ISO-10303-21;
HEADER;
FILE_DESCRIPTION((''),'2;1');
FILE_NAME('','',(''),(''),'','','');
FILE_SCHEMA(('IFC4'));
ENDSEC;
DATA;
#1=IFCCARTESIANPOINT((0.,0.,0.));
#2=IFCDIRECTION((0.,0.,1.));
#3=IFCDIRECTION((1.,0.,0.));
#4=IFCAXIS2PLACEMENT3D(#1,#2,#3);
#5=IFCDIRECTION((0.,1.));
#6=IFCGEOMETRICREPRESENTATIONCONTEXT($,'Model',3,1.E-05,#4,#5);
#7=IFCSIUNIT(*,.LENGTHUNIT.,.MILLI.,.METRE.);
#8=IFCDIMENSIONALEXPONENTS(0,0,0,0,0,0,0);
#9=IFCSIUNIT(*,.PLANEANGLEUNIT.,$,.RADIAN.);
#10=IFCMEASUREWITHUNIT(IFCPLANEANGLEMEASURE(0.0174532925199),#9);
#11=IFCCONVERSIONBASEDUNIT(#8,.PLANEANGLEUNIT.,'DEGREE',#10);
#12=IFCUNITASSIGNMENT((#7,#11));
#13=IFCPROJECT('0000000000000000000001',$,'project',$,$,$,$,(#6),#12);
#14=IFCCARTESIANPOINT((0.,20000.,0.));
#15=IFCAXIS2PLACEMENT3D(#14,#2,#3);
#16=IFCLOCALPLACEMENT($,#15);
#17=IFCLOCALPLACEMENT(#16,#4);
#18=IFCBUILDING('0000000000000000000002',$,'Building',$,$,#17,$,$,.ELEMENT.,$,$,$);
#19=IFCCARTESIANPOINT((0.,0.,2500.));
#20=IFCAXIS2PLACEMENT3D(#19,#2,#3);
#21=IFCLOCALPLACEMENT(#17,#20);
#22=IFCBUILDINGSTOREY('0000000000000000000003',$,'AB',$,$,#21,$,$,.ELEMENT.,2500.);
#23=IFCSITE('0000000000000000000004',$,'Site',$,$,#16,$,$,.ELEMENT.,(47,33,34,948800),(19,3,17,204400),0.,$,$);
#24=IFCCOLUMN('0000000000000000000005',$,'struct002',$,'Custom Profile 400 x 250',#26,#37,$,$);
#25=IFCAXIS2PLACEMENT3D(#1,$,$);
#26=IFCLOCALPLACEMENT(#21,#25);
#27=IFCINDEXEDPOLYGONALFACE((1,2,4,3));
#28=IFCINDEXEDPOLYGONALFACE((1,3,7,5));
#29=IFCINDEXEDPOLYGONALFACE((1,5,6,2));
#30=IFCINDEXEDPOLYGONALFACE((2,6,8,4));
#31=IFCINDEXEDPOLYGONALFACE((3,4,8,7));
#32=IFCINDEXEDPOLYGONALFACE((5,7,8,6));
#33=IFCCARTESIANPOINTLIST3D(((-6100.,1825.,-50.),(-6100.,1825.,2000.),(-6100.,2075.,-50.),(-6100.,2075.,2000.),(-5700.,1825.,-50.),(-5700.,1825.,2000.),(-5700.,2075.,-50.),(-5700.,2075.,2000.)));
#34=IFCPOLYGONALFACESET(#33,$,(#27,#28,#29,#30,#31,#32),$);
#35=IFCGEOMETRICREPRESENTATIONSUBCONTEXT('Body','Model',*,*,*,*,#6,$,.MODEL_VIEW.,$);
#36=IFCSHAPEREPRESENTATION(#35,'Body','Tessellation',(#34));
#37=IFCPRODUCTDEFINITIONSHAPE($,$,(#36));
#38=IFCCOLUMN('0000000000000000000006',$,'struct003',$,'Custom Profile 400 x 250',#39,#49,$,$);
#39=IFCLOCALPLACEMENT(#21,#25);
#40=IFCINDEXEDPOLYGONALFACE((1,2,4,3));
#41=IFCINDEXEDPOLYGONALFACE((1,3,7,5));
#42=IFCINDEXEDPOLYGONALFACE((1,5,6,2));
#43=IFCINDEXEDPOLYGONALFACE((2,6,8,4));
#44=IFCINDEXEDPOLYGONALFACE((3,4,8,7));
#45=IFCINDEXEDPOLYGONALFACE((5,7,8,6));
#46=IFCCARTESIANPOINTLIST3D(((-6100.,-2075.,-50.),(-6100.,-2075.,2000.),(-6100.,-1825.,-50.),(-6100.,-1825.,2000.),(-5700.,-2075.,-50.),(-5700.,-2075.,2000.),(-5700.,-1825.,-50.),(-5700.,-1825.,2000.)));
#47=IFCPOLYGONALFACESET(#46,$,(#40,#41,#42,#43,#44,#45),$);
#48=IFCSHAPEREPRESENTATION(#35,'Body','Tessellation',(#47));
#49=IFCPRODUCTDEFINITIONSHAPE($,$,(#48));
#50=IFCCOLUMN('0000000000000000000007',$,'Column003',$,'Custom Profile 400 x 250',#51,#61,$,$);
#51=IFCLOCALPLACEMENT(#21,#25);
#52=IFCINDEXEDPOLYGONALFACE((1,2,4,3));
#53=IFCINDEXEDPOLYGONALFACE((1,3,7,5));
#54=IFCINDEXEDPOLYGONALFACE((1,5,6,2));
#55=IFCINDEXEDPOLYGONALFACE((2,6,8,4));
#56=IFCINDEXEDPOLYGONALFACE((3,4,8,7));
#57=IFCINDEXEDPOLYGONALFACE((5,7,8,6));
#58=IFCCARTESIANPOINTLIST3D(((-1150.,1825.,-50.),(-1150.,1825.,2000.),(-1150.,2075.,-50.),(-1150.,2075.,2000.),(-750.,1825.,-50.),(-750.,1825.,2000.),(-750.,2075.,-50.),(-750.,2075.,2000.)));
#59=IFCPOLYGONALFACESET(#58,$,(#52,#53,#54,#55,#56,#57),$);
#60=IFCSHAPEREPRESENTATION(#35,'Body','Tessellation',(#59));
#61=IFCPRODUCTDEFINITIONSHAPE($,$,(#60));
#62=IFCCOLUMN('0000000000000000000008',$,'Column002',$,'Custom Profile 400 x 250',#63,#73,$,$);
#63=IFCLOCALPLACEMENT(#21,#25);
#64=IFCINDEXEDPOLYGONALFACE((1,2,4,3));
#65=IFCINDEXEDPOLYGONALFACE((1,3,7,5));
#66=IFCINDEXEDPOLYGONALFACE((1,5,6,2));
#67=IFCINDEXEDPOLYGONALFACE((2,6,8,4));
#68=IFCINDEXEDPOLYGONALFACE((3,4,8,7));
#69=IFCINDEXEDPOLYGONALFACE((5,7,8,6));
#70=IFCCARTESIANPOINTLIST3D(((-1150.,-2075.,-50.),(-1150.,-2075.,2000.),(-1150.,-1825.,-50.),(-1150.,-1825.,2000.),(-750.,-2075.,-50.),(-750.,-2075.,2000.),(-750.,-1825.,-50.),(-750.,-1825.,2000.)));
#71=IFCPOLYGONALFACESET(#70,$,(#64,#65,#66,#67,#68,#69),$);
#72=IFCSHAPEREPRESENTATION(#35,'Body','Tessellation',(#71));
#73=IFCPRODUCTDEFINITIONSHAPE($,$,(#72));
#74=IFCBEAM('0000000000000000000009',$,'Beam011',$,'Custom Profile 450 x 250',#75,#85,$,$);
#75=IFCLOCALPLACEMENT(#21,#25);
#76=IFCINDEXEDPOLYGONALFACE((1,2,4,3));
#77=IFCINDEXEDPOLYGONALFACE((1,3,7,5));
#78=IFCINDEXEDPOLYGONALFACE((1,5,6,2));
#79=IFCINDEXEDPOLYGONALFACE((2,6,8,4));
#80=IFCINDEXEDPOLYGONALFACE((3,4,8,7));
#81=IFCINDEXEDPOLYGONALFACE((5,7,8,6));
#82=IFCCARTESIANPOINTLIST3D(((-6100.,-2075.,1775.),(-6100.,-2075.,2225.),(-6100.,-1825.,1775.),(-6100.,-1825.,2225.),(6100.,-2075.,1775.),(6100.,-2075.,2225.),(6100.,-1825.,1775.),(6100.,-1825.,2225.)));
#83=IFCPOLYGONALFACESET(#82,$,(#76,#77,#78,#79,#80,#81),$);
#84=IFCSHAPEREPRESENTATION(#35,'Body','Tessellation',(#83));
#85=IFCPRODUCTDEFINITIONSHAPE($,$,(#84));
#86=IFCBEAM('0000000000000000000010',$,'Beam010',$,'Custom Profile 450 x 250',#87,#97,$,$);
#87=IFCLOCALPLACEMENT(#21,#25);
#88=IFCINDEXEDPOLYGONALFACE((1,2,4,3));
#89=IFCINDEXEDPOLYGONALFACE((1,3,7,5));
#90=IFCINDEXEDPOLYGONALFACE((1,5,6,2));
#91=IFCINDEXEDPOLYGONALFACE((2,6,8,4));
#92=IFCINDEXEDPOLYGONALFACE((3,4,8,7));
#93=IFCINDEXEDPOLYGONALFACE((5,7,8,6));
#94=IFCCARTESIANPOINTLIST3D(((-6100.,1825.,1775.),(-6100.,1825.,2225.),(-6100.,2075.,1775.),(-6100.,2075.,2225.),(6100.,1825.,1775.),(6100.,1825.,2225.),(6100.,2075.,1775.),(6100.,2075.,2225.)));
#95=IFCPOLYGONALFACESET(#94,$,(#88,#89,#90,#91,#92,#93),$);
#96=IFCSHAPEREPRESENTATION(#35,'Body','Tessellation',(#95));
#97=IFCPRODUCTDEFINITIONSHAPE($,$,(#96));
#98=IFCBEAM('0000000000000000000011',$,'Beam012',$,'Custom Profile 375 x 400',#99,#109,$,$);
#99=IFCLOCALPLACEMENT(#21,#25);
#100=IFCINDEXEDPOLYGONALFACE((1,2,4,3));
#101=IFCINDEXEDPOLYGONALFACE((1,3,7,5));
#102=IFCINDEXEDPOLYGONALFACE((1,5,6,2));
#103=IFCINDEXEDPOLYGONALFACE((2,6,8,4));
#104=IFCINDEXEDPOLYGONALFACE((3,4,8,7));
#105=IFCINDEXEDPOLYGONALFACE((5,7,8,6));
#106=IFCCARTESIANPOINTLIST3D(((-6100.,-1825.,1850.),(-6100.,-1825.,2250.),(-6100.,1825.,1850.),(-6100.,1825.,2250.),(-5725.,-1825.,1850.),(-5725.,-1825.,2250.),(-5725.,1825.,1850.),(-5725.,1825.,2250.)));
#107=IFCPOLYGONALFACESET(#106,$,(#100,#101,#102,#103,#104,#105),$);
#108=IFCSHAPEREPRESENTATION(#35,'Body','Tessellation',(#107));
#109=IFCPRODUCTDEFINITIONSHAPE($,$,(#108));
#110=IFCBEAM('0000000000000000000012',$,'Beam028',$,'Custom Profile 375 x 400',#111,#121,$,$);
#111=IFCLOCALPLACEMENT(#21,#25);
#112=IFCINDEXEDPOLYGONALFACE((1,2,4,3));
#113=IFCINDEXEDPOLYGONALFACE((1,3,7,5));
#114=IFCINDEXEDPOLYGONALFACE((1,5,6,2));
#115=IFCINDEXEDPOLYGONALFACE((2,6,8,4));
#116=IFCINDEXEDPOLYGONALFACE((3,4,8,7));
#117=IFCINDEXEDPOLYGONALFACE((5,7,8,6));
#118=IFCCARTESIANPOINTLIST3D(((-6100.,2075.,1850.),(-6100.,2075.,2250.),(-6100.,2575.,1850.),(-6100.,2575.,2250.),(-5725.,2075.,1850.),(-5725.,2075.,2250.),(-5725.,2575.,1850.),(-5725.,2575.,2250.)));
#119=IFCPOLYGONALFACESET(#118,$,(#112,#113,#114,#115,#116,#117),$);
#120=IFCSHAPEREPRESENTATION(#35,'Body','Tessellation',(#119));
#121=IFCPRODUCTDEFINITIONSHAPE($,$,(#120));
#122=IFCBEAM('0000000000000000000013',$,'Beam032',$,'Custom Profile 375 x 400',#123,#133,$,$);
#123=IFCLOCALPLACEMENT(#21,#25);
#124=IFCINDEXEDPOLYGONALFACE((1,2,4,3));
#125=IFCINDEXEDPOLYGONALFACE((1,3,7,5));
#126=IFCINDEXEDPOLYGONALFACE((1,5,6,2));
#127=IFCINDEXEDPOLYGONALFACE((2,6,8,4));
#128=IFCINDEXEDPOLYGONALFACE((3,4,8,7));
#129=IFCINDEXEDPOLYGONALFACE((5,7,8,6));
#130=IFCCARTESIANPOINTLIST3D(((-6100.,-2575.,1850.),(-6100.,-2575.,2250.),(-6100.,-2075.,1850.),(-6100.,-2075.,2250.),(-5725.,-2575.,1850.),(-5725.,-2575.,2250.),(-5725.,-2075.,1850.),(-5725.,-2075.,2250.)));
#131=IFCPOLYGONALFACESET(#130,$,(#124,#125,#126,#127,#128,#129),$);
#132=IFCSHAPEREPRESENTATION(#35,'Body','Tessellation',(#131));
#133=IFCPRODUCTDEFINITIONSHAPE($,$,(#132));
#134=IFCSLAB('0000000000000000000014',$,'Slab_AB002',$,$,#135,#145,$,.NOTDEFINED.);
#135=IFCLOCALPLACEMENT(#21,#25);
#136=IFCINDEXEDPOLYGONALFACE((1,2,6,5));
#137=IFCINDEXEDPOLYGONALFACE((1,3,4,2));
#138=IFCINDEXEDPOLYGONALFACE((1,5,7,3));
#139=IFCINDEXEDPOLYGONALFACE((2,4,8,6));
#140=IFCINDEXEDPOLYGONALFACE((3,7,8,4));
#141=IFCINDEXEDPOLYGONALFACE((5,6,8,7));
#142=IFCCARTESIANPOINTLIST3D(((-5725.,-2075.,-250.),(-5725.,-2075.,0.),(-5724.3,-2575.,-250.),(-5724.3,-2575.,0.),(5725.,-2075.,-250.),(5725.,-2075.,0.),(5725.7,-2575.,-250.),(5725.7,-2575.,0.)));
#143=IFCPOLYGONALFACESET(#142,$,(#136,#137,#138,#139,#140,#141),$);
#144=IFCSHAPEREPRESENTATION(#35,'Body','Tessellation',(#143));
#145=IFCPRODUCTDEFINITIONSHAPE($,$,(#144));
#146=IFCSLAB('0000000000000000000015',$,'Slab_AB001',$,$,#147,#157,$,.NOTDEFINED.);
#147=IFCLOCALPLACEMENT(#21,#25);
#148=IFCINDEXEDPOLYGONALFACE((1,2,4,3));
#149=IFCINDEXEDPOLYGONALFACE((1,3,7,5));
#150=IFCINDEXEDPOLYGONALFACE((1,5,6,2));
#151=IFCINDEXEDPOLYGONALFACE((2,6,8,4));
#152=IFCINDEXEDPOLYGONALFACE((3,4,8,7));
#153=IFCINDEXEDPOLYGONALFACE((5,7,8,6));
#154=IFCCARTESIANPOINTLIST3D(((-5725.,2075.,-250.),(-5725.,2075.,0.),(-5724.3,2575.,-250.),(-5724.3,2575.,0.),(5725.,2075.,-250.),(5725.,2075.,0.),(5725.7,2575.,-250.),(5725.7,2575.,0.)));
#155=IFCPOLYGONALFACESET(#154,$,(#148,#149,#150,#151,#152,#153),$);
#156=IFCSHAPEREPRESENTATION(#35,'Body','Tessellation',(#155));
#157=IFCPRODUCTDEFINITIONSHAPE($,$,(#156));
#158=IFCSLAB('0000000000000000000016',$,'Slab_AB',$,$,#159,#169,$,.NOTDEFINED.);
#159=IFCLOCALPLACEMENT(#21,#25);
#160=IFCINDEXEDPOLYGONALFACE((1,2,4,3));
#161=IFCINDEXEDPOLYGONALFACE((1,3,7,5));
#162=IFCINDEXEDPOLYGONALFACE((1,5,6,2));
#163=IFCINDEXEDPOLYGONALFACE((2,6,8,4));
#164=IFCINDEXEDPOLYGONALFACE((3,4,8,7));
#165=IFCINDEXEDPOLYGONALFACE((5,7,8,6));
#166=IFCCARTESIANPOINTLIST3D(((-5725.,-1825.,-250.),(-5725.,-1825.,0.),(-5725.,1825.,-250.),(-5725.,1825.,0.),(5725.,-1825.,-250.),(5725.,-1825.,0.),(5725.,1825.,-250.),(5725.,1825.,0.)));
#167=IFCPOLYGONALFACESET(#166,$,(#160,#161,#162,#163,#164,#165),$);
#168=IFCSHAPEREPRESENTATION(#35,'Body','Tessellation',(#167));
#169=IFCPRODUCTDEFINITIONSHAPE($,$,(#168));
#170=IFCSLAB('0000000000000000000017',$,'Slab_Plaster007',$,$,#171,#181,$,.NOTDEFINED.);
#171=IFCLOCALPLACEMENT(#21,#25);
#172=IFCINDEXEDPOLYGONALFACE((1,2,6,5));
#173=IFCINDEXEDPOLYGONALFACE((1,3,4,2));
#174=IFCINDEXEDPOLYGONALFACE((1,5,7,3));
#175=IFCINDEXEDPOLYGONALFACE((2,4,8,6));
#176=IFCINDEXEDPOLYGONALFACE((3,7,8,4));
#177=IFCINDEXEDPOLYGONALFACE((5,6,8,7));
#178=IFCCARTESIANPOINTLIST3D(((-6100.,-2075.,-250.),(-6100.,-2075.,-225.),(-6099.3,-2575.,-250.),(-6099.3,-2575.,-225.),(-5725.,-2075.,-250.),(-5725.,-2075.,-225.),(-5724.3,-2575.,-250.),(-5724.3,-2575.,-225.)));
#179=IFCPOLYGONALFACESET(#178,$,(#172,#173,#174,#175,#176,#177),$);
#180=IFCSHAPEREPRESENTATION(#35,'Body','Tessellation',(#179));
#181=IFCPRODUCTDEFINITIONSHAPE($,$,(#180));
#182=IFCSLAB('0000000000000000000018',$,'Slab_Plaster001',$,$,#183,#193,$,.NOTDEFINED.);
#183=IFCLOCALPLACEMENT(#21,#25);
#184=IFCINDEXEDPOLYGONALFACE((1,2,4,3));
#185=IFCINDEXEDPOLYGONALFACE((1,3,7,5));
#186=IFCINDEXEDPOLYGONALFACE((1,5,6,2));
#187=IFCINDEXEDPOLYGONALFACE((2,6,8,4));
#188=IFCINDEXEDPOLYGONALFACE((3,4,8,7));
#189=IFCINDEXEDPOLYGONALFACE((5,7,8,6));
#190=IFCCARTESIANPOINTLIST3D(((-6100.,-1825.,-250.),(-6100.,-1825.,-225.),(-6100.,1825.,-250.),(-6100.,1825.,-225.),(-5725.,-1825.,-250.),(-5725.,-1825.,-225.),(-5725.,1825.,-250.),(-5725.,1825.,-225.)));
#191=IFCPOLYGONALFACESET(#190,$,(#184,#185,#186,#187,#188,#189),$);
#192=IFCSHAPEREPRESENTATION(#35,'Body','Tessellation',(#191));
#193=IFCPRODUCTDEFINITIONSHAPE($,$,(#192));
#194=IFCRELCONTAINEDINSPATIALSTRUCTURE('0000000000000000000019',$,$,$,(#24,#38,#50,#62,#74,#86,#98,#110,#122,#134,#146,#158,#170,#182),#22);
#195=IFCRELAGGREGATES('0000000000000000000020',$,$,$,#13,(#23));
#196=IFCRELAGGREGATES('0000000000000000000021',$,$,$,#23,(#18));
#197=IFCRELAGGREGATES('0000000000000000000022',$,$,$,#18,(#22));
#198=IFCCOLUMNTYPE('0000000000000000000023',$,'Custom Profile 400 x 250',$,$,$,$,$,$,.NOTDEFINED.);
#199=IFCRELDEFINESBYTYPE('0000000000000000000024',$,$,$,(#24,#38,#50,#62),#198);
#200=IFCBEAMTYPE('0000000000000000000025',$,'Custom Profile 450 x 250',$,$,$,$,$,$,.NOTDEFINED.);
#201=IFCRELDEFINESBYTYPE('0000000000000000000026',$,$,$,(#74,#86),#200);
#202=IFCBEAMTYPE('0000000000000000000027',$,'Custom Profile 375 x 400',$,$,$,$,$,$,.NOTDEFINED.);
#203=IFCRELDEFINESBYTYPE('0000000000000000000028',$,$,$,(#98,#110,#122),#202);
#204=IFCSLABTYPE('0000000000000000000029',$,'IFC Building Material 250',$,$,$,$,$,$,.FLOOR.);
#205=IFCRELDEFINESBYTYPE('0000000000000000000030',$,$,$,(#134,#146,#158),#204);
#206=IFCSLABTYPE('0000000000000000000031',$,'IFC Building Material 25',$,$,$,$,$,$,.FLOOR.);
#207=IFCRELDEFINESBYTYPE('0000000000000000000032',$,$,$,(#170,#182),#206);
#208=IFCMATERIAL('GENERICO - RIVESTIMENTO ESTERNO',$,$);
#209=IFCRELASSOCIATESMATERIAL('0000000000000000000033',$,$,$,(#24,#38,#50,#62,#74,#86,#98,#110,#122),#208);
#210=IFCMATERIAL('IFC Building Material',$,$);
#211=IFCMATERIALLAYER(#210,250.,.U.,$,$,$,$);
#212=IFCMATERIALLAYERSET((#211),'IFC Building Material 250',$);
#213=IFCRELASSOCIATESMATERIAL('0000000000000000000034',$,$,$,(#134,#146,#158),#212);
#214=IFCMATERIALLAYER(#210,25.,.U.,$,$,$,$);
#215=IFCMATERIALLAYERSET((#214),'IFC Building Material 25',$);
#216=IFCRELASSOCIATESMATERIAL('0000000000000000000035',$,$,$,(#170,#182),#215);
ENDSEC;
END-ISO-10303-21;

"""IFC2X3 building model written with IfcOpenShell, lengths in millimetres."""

from ifc_helpers import new_model, entity, si_unit, converted_unit, direction, frame, frame_2d, origin_with_axes, origin_2d_with_axis, place, context, subcontext, project, spatial, polyline, rectangle, outline, extrude, material, layer, layer_set, layer_usage, type_object, element, save


model = new_model("IFC2X3")

# Units and contexts
model_context = context("Model", 3, precision=1e-05, world=origin_with_axes(), true_north=direction((0.0, 1.0)))
body_context = subcontext(model_context, "Body", "Model", "MODEL_VIEW")
ifc_project = project(units=[si_unit("LENGTHUNIT", "METRE", prefix="MILLI"), converted_unit("PLANEANGLEUNIT", "DEGREE", entity("IfcPlaneAngleMeasure", 0.0174532925199), si_unit("PLANEANGLEUNIT", "RADIAN"), dimensions=[0, 0, 0, 0, 0, 0, 0])], contexts=[model_context])

# Site, building, storey
site_placement = place(None, frame((0.0, 20000.0, 0.0), z_axis=(0.0, 0.0, 1.0), x_axis=(1.0, 0.0, 0.0)))
site = spatial("IfcSite", under=ifc_project, at=site_placement, Name="Site", CompositionType="ELEMENT", RefLatitude=(47, 33, 34, 948800), RefLongitude=(19, 3, 17, 204400), RefElevation=0.0)
building_placement = place(site_placement, origin_with_axes())
building = spatial("IfcBuilding", under=site, at=building_placement, Name="Building", CompositionType="ELEMENT")
storey_placement = place(building_placement, frame((0.0, 0.0, 2500.0), z_axis=(0.0, 0.0, 1.0), x_axis=(1.0, 0.0, 0.0)))
storey = spatial("IfcBuildingStorey", under=building, at=storey_placement, Name="AB", CompositionType="ELEMENT", Elevation=2500.0)

# Columns
ifc_material_1 = material(Name="GENERICO - RIVESTIMENTO ESTERNO")
column_type = type_object("IfcColumnType", Name="Custom Profile 400 x 250", PredefinedType="NOTDEFINED")
for number, where, z_axis, x_axis, name in (
    (1, (-5900.0, 1950.0, -50.0), (0.0, 0.0, 1.0), (1.0, 0.0, 0.0), "struct002"),
    (2, (-5900.0, -1950.0, -50.0), (0.0, 0.0, 1.0), (1.0, 0.0, 0.0), "struct003"),
    (3, (-950.0, 1950.0, -50.0), (0.0, 0.0, 1.0), (1.0, 0.0, 0.0), "Column003"),
    (4, (-950.0, -1950.0, -50.0), (0.0, 0.0, 1.0), (1.0, 0.0, 0.0), "Column002"),
):
    element("IfcColumn", number, at=place(storey_placement, frame(where, z_axis=z_axis, x_axis=x_axis)), inside=storey, type_object=column_type, material=ifc_material_1, Name=name, ObjectType="Custom Profile 400 x 250", context=body_context, shape_type="SweptSolid", body=[
        extrude(rectangle(XDim=400.0, YDim=250.0, at=origin_2d_with_axis()), origin_with_axes(), (0.0, 0.0, 1.0), 2050.0),
    ])

# Beams
beam_type_1 = type_object("IfcBeamType", Name="Custom Profile 450 x 250", PredefinedType="NOTDEFINED")
for number, where, z_axis, x_axis, name in (
    (5, (-6100.0, -1950.0, 2225.0), (0.0, 0.0, 1.0), (0.0, -1.0, 0.0), "Beam011"),
    (6, (-6100.0, 1950.0, 2225.0), (0.0, 0.0, 1.0), (0.0, -1.0, 0.0), "Beam010"),
):
    element("IfcBeam", number, at=place(storey_placement, frame(where, z_axis=z_axis, x_axis=x_axis)), inside=storey, type_object=beam_type_1, material=ifc_material_1, Name=name, ObjectType="Custom Profile 450 x 250", context=body_context, shape_type="SweptSolid", body=[
        extrude(rectangle(XDim=450.0, YDim=250.0, at=frame_2d((-225.0, 0.0), x_axis=(1.0, 0.0))), frame((0.0, 0.0, 0.0), z_axis=(0.0, 1.0, 0.0), x_axis=(0.0, 0.0, 1.0)), (0.0, 0.0, 1.0), 12200.0),
    ])
beam_type_2 = type_object("IfcBeamType", Name="Custom Profile 375 x 400", PredefinedType="NOTDEFINED")
beam_placement = place(storey_placement, frame((-5912.5, -1825.0, 2250.0), z_axis=(0.0, 0.0, 1.0), x_axis=(1.0, 0.0, 0.0)))
element("IfcBeam", 7, at=beam_placement, inside=storey, type_object=beam_type_2, material=ifc_material_1, Name="Beam012", ObjectType="Custom Profile 375 x 400", context=body_context, shape_type="SweptSolid", body=[
    extrude(rectangle(XDim=400.0, YDim=375.0, at=frame_2d((-200.0, 0.0), x_axis=(1.0, 0.0))), frame((0.0, 0.0, 0.0), z_axis=(0.0, 1.0, 0.0), x_axis=(0.0, 0.0, 1.0)), (0.0, 0.0, 1.0), 3650.0),
])
for number, where, z_axis, x_axis, name in (
    (8, (-5912.5, 2075.0, 2250.0), (0.0, 0.0, 1.0), (1.0, 0.0, 0.0), "Beam028"),
    (9, (-5912.5, -2575.0, 2250.0), (0.0, 0.0, 1.0), (1.0, 0.0, 0.0), "Beam032"),
):
    element("IfcBeam", number, at=place(storey_placement, frame(where, z_axis=z_axis, x_axis=x_axis)), inside=storey, type_object=beam_type_2, material=ifc_material_1, Name=name, ObjectType="Custom Profile 375 x 400", context=body_context, shape_type="SweptSolid", body=[
        extrude(rectangle(XDim=400.0, YDim=375.0, at=frame_2d((-200.0, 0.0), x_axis=(1.0, 0.0))), frame((0.0, 0.0, 0.0), z_axis=(0.0, 1.0, 0.0), x_axis=(0.0, 0.0, 1.0)), (0.0, 0.0, 1.0), 500.0),
    ])

# Slabs
ifc_material_2 = material(Name="IFC Building Material")
ifc_layer_1 = layer(ifc_material_2, 250.0, ventilated="UNKNOWN")
ifc_layer_set_1 = layer_set([ifc_layer_1], Name="IFC Building Material 250")
ifc_layer_usage_1 = layer_usage(ifc_layer_set_1, "AXIS3", "NEGATIVE", 250.0)
slab_type_1 = type_object("IfcSlabType", Name="IFC Building Material 250", PredefinedType="FLOOR")
slab_1_placement = place(storey_placement, frame((-5724.3, -2575.0, 0.0), z_axis=(0.0, 0.0, 1.0), x_axis=(1.0, 0.0, 0.0)))
element("IfcSlab", 10, at=slab_1_placement, inside=storey, type_object=slab_type_1, material=ifc_layer_usage_1, Name="Slab_AB002", PredefinedType="NOTDEFINED", context=body_context, shape_type="SweptSolid", body=[
    extrude(outline(polyline([(0.0, 0.0), (11450.0, 0.0), (11449.3, 500.0), (-0.7, 500.0), (0.0, 0.0)])), frame((0.0, 0.0, -250.0), z_axis=(0.0, 0.0, 1.0), x_axis=(1.0, 0.0, 0.0)), (0.0, 0.0, 1.0), 250.0),
])
ifc_layer_usage_2 = layer_usage(ifc_layer_set_1, "AXIS3", "NEGATIVE", 250.0)
slab_2_placement = place(storey_placement, frame((-5724.3, 2575.0, 0.0), z_axis=(0.0, 0.0, 1.0), x_axis=(1.0, 0.0, 0.0)))
element("IfcSlab", 11, at=slab_2_placement, inside=storey, type_object=slab_type_1, material=ifc_layer_usage_2, Name="Slab_AB001", PredefinedType="NOTDEFINED", context=body_context, shape_type="SweptSolid", body=[
    extrude(outline(polyline([(0.0, 0.0), (-0.7, -500.0), (11449.3, -500.0), (11450.0, 0.0), (0.0, 0.0)])), frame((0.0, 0.0, -250.0), z_axis=(0.0, 0.0, 1.0), x_axis=(1.0, 0.0, 0.0)), (0.0, 0.0, 1.0), 250.0),
])
ifc_layer_usage_3 = layer_usage(ifc_layer_set_1, "AXIS3", "NEGATIVE", 250.0)
slab_3_placement = place(storey_placement, frame((-5725.0, -1825.0, 0.0), z_axis=(0.0, 0.0, 1.0), x_axis=(1.0, 0.0, 0.0)))
element("IfcSlab", 12, at=slab_3_placement, inside=storey, type_object=slab_type_1, material=ifc_layer_usage_3, Name="Slab_AB", PredefinedType="NOTDEFINED", context=body_context, shape_type="SweptSolid", body=[
    extrude(outline(polyline([(0.0, 0.0), (11450.0, 0.0), (11450.0, 3650.0), (0.0, 3650.0), (0.0, 0.0)])), frame((0.0, 0.0, -250.0), z_axis=(0.0, 0.0, 1.0), x_axis=(1.0, 0.0, 0.0)), (0.0, 0.0, 1.0), 250.0),
])
ifc_layer_2 = layer(ifc_material_2, 25.0, ventilated="UNKNOWN")
ifc_layer_set_2 = layer_set([ifc_layer_2], Name="IFC Building Material 25")
ifc_layer_usage_4 = layer_usage(ifc_layer_set_2, "AXIS3", "NEGATIVE", 25.0)
slab_type_2 = type_object("IfcSlabType", Name="IFC Building Material 25", PredefinedType="FLOOR")
slab_4_placement = place(storey_placement, frame((-5725.0, -2075.0, -225.0), z_axis=(0.0, 0.0, 1.0), x_axis=(1.0, 0.0, 0.0)))
element("IfcSlab", 13, at=slab_4_placement, inside=storey, type_object=slab_type_2, material=ifc_layer_usage_4, Name="Slab_Plaster007", PredefinedType="NOTDEFINED", context=body_context, shape_type="SweptSolid", body=[
    extrude(outline(polyline([(0.0, 0.0), (-375.0, 0.0), (-374.3, -500.0), (0.7, -500.0), (0.0, 0.0)])), frame((0.0, 0.0, -25.0), z_axis=(0.0, 0.0, 1.0), x_axis=(1.0, 0.0, 0.0)), (0.0, 0.0, 1.0), 25.0),
])
ifc_layer_usage_5 = layer_usage(ifc_layer_set_2, "AXIS3", "NEGATIVE", 25.0)
slab_5_placement = place(storey_placement, frame((-5725.0, -1825.0, -225.0), z_axis=(0.0, 0.0, 1.0), x_axis=(1.0, 0.0, 0.0)))
element("IfcSlab", 14, at=slab_5_placement, inside=storey, type_object=slab_type_2, material=ifc_layer_usage_5, Name="Slab_Plaster001", PredefinedType="NOTDEFINED", context=body_context, shape_type="SweptSolid", body=[
    extrude(outline(polyline([(0.0, 0.0), (0.0, 3650.0), (-375.0, 3650.0), (-375.0, 0.0), (0.0, 0.0)])), frame((0.0, 0.0, -25.0), z_axis=(0.0, 0.0, 1.0), x_axis=(1.0, 0.0, 0.0)), (0.0, 0.0, 1.0), 25.0),
])

save(model, "model.ifc")
